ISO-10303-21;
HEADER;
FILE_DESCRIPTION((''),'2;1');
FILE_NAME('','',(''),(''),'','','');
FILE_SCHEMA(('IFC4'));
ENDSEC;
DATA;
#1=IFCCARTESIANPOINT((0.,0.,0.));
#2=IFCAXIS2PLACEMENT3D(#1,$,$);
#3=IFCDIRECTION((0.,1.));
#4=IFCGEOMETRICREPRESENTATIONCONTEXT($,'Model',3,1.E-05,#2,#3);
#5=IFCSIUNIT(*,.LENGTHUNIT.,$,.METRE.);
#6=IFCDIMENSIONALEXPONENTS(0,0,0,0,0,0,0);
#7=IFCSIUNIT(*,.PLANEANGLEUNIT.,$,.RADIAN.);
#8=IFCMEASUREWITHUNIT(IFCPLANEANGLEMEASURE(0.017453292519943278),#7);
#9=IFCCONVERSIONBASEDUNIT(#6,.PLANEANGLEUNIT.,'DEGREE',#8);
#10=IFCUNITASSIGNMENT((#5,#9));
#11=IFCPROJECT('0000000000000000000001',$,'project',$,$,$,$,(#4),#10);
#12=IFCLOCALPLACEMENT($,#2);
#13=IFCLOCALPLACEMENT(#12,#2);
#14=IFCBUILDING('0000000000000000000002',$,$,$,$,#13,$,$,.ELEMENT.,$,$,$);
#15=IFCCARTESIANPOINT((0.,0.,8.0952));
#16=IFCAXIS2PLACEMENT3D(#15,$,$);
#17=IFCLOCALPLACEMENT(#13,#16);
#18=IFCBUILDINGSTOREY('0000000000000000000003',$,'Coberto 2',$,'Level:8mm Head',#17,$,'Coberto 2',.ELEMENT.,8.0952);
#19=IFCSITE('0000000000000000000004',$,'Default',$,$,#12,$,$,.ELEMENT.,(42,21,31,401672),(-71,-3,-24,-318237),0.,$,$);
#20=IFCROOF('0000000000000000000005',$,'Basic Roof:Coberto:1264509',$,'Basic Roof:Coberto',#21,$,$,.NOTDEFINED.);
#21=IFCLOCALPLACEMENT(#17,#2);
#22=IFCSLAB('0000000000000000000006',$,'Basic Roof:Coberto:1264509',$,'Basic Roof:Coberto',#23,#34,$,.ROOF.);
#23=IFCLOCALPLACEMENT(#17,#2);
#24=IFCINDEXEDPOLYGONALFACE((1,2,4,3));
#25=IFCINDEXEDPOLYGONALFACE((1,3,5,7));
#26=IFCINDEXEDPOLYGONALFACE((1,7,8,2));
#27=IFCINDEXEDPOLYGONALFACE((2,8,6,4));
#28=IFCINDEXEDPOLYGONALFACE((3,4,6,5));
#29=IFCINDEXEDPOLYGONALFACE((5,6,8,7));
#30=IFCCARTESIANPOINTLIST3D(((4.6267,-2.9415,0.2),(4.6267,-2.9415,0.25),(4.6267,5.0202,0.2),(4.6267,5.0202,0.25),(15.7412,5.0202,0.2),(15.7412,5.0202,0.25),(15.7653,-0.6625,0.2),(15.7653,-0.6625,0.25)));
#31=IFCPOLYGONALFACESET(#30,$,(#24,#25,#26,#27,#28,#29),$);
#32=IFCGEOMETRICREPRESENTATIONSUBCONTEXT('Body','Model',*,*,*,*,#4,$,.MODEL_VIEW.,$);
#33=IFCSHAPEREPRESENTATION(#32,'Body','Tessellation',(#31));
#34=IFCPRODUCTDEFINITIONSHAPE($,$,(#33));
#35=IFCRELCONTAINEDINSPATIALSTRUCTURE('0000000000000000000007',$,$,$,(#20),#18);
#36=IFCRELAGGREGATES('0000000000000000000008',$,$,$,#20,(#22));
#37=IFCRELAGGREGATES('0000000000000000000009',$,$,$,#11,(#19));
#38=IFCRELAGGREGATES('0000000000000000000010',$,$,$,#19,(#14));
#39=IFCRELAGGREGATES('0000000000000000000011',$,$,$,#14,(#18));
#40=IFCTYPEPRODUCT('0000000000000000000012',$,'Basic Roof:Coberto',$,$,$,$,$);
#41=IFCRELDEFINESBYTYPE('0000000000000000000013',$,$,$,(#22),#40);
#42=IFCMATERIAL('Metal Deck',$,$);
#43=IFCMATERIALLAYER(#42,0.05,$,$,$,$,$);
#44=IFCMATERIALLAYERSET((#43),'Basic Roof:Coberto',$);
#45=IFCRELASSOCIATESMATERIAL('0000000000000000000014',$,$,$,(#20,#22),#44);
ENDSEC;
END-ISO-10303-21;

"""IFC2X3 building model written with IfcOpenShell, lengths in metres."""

from ifc_helpers import new_model, entity, si_unit, converted_unit, direction, frame, origin, place, context, subcontext, project, spatial, polyline, outline, extrude, material, layer, layer_set, type_object, element, aggregate, save


model = new_model("IFC2X3")

# Units and contexts
model_context = context("Model", 3, precision=1e-05, world=origin(), true_north=direction((0.0, 1.0)))
body_context = subcontext(model_context, "Body", "Model", "MODEL_VIEW")
ifc_project = project(units=[si_unit("LENGTHUNIT", "METRE"), converted_unit("PLANEANGLEUNIT", "DEGREE", entity("IfcPlaneAngleMeasure", 0.017453292519943278), si_unit("PLANEANGLEUNIT", "RADIAN"), dimensions=[0, 0, 0, 0, 0, 0, 0])], contexts=[model_context])

# Site, building, storey
site_placement = place(None, origin())
site = spatial("IfcSite", under=ifc_project, at=site_placement, Name="Default", CompositionType="ELEMENT", RefLatitude=(42, 21, 31, 401672), RefLongitude=(-71, -3, -24, -318237), RefElevation=0.0)
building_placement = place(site_placement, origin())
building = spatial("IfcBuilding", under=site, at=building_placement, CompositionType="ELEMENT")
storey_placement = place(building_placement, frame((0.0, 0.0, 8.0952)))
storey = spatial("IfcBuildingStorey", under=building, at=storey_placement, Name="Coberto 2", ObjectType="Level:8mm Head", LongName="Coberto 2", CompositionType="ELEMENT", Elevation=8.0952)

# Roof, slab
ifc_material = material(Name="Metal Deck")
ifc_layer = layer(ifc_material, 0.05)
ifc_layer_set = layer_set([ifc_layer], Name="Basic Roof:Coberto")
roof_placement = place(storey_placement, frame((4.6267, -2.9415, 0.2)))
roof = element("IfcRoof", 1, at=roof_placement, inside=storey, material=ifc_layer_set, Name="Basic Roof:Coberto:1264509", ObjectType="Basic Roof:Coberto", ShapeType="NOTDEFINED")
type_product = type_object("IfcTypeProduct", Name="Basic Roof:Coberto")
slab_placement = place(roof_placement, origin())
slab = element("IfcSlab", 2, at=slab_placement, type_object=type_product, material=ifc_layer_set, Name="Basic Roof:Coberto:1264509", ObjectType="Basic Roof:Coberto", PredefinedType="ROOF", context=body_context, shape_type="SweptSolid", body=[
    extrude(outline(polyline([(-5.5693, 3.9808), (-5.5693, -3.9808), (5.5693, -1.7019), (5.5453, 3.9808), (-5.5693, 3.9808)])), frame((5.5693, 3.9808, 0.0)), (0.0, 0.0, 1.0), 0.05),
])
aggregate(roof, [slab])

save(model, "model.ifc")
